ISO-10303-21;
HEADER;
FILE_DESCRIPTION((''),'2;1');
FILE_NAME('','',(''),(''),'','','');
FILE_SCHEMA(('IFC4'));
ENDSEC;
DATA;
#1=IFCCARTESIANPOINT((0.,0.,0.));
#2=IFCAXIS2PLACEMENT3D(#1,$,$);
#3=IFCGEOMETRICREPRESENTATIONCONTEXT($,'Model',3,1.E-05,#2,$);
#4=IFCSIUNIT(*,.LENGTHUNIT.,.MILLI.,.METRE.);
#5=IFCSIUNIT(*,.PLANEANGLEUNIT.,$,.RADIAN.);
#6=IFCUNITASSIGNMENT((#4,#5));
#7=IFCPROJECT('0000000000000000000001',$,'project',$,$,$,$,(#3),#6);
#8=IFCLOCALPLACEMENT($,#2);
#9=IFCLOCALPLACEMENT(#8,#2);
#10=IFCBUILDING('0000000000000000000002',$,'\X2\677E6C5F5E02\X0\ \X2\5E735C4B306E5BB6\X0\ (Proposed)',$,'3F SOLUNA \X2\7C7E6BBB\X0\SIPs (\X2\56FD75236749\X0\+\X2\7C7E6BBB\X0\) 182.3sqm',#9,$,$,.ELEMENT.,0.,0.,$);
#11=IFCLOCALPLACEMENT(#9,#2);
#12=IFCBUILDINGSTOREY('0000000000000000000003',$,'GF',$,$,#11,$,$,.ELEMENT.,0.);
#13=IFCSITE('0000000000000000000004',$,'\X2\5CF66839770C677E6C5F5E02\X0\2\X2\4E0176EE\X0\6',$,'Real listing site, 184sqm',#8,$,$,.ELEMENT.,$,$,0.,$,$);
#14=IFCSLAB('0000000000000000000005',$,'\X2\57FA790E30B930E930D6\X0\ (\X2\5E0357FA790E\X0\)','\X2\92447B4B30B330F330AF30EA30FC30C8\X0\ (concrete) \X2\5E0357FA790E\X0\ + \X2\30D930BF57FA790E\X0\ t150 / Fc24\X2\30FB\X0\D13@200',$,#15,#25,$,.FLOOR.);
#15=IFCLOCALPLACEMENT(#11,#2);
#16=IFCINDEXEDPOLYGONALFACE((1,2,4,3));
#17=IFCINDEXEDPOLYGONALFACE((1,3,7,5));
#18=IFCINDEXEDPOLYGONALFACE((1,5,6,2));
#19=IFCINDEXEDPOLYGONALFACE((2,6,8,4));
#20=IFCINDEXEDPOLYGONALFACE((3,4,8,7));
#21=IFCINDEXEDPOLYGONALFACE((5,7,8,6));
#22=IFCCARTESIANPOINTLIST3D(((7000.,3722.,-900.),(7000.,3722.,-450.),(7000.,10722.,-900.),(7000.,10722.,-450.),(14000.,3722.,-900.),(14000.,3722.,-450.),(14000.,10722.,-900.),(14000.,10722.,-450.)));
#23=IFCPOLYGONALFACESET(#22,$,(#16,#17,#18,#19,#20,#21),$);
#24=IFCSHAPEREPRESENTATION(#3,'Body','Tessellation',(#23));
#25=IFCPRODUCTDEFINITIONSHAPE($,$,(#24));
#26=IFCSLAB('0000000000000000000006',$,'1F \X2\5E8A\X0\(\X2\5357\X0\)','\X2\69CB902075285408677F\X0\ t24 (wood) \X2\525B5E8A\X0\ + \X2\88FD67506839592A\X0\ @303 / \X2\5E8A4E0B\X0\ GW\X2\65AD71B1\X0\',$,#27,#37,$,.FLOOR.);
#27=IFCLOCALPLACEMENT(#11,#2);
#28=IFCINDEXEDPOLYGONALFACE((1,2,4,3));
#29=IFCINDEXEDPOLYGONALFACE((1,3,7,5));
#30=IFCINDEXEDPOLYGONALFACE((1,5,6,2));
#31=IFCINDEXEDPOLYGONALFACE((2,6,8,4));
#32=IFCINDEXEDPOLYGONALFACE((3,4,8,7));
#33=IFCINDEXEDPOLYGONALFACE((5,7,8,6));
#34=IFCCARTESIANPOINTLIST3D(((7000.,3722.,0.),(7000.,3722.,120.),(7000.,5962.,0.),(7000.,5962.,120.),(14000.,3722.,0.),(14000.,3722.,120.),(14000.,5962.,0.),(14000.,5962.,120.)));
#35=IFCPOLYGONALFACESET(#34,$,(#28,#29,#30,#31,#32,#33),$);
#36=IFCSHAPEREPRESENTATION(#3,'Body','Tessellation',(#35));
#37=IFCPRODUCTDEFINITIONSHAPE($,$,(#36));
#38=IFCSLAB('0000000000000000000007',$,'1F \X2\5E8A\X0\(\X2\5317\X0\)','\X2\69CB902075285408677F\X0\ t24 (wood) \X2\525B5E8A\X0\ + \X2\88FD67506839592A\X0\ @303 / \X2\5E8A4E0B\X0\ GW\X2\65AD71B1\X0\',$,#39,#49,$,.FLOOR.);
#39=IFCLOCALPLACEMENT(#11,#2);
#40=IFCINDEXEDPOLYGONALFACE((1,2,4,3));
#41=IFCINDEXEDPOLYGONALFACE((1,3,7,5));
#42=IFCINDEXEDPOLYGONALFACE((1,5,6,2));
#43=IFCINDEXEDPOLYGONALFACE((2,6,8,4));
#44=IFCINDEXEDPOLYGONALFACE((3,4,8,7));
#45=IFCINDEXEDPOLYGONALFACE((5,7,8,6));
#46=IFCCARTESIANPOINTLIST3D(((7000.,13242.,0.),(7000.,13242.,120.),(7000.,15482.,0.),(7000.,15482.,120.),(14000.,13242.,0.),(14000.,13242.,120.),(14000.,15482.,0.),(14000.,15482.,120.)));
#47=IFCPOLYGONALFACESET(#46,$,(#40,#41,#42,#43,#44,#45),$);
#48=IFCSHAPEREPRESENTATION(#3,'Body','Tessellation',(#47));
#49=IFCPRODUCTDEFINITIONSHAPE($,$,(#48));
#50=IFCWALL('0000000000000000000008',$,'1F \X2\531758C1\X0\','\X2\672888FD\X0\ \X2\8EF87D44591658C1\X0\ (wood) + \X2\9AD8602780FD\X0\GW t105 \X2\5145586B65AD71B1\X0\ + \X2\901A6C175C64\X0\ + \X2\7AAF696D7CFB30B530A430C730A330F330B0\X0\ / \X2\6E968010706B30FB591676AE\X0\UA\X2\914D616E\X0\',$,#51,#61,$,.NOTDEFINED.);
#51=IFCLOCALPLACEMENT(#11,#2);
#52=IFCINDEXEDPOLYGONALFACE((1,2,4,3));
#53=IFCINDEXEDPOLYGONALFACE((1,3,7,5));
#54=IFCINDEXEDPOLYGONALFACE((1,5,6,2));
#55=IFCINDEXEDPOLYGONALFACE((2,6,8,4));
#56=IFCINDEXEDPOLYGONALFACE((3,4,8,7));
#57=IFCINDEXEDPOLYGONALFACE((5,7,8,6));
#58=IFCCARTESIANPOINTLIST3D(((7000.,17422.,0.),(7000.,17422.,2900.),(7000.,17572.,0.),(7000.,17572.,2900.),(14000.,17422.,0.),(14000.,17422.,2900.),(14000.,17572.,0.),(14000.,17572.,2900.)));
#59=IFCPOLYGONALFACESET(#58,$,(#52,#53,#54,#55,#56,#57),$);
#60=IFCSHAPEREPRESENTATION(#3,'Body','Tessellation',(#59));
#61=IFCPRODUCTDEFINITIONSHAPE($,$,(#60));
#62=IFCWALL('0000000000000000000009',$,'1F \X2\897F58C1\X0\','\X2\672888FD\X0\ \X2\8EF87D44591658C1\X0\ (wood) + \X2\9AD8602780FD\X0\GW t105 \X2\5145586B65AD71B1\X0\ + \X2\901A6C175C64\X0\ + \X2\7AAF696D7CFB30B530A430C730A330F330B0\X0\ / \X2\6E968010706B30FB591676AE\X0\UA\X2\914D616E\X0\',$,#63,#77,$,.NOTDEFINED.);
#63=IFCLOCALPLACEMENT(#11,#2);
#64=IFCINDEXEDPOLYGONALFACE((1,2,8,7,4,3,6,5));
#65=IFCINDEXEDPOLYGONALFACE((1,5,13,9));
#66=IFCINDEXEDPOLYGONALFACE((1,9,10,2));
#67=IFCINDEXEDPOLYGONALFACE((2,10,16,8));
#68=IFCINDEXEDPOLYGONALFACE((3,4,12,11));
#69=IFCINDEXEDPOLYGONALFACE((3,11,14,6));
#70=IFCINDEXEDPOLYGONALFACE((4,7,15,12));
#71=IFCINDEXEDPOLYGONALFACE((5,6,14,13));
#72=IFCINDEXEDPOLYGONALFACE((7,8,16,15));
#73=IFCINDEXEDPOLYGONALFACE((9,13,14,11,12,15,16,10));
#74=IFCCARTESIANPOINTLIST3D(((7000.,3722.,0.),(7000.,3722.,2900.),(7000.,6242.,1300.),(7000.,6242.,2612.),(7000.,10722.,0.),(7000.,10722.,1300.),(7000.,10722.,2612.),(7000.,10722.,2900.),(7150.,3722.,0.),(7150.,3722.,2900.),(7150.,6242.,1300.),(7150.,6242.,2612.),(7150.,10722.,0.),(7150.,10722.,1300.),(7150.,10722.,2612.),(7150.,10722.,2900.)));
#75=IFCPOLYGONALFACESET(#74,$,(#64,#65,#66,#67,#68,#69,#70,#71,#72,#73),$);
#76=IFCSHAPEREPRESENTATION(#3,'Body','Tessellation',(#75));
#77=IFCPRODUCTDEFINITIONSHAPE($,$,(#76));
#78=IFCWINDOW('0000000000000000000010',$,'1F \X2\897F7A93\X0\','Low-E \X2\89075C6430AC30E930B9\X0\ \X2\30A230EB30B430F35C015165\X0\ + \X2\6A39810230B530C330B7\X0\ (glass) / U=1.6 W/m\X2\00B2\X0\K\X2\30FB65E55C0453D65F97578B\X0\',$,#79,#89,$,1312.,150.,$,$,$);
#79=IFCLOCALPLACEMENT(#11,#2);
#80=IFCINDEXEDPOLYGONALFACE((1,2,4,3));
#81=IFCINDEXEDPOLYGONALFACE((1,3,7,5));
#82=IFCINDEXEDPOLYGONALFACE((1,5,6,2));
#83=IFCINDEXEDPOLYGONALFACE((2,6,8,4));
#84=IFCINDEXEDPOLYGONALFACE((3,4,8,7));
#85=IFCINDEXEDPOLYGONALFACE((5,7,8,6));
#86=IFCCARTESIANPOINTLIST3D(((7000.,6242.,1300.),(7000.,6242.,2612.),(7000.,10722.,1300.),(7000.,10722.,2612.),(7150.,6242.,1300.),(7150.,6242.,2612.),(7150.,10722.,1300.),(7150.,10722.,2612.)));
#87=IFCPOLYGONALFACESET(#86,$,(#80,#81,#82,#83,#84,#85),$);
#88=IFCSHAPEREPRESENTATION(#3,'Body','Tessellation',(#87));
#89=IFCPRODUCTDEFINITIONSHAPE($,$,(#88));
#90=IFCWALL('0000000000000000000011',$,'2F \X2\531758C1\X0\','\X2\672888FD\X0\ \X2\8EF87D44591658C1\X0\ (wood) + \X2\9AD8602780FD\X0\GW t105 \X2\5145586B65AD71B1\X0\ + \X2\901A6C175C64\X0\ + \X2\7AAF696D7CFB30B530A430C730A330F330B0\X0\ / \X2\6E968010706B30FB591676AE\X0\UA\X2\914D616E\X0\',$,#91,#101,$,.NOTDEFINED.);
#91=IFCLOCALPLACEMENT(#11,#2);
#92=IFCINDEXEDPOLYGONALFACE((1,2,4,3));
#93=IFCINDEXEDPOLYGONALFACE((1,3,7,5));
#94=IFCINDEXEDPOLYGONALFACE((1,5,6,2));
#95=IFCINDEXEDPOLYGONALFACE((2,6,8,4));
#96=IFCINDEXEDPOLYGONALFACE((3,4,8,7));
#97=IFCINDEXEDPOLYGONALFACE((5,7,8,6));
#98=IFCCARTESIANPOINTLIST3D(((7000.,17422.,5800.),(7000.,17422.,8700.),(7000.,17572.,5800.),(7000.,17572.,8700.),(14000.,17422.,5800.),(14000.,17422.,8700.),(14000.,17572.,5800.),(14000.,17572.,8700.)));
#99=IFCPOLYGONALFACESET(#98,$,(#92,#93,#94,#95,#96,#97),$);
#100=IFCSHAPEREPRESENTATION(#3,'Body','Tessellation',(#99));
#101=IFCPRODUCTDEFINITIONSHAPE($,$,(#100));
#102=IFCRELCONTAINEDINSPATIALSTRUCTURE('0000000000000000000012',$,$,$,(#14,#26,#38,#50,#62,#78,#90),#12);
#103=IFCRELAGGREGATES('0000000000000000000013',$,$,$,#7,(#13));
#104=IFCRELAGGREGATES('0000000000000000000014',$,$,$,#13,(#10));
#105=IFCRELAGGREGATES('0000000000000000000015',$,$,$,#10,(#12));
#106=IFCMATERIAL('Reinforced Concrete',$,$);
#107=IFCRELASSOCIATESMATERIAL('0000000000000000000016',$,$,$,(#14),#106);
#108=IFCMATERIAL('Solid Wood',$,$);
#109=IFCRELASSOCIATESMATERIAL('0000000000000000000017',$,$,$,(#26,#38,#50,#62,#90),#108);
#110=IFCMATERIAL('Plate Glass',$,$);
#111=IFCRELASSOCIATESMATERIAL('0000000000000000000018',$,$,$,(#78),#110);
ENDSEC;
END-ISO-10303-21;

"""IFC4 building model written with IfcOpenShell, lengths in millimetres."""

from ifc_helpers import new_model, si_unit, frame, frame_2d, origin, place, context, project, spatial, rectangle, extrude, material, element, fill, save


model = new_model("IFC4")

# Units and contexts
model_context = context("Model", 3, precision=1e-05, world=origin())
ifc_project = project(units=[si_unit("LENGTHUNIT", "METRE", prefix="MILLI"), si_unit("PLANEANGLEUNIT", "RADIAN")], contexts=[model_context])

# Site, building, storey
site_placement = place(None, origin())
site = spatial("IfcSite", under=ifc_project, at=site_placement, Name="島根県松江市2丁目6", ObjectType="Real listing site, 184sqm", CompositionType="ELEMENT", RefElevation=0.0)
building_placement = place(site_placement, origin())
building = spatial("IfcBuilding", under=site, at=building_placement, Name="松江市 平屋の家 (Proposed)", ObjectType="3F SOLUNA 籾殻SIPs (国産杉+籾殻) 182.3sqm", CompositionType="ELEMENT", ElevationOfRefHeight=0.0, ElevationOfTerrain=0.0)
storey_placement = place(building_placement, origin())
storey = spatial("IfcBuildingStorey", under=building, at=storey_placement, Name="GF", CompositionType="ELEMENT", Elevation=0.0)

# Slabs
ifc_material_1 = material(Name="Reinforced Concrete")
slab_1_placement = place(storey_placement, frame((3500.0, 1861.0, -450.0)))
element("IfcSlab", 1, at=slab_1_placement, inside=storey, material=ifc_material_1, Name="基礎スラブ (布基礎)", Description="鉄筋コンクリート (concrete) 布基礎 + ベタ基礎 t150 / Fc24・D13@200", PredefinedType="FLOOR", context=model_context, shape_type="SweptSolid", body=[
    extrude(rectangle(XDim=7000.0, YDim=7000.0, at=frame_2d((3500.0, 3500.0))), frame((3500.0, 1861.0, -450.0)), (0.0, 0.0, 1.0), 450.0),
])
ifc_material_2 = material(Name="Solid Wood")
slab_2_placement = place(storey_placement, frame((3500.0, 1861.0, 0.0)))
element("IfcSlab", 2, at=slab_2_placement, inside=storey, material=ifc_material_2, Name="1F 床(南)", Description="構造用合板 t24 (wood) 剛床 + 製材根太 @303 / 床下 GW断熱", PredefinedType="FLOOR", context=model_context, shape_type="SweptSolid", body=[
    extrude(rectangle(XDim=7000.0, YDim=2240.0, at=frame_2d((3500.0, 1120.0))), frame((3500.0, 1861.0, 0.0)), (0.0, 0.0, 1.0), 120.0),
])
slab_3_placement = place(storey_placement, frame((3500.0, 6621.0, 0.0)))
element("IfcSlab", 3, at=slab_3_placement, inside=storey, material=ifc_material_2, Name="1F 床(北)", Description="構造用合板 t24 (wood) 剛床 + 製材根太 @303 / 床下 GW断熱", PredefinedType="FLOOR", context=model_context, shape_type="SweptSolid", body=[
    extrude(rectangle(XDim=7000.0, YDim=2240.0, at=frame_2d((3500.0, 1120.0))), frame((3500.0, 6621.0, 0.0)), (0.0, 0.0, 1.0), 120.0),
])

# Shared definitions
ifc_material_3 = material(Name="Plate Glass")

# Wall
wall_1_placement = place(storey_placement, frame((3500.0, 8711.0, 0.0)))
element("IfcWall", 4, at=wall_1_placement, inside=storey, material=ifc_material_2, Name="1F 北壁", Description="木製 軸組外壁 (wood) + 高性能GW t105 充填断熱 + 通気層 + 窯業系サイディング / 準耐火・外皮UA配慮", PredefinedType="NOTDEFINED", context=model_context, shape_type="SweptSolid", body=[
    extrude(rectangle(XDim=7000.0, YDim=150.0, at=frame_2d((3500.0, 75.0))), frame((3500.0, 8711.0, 0.0)), (0.0, 0.0, 1.0), 2900.0),
])

# Wall, opening, window
wall_2_placement = place(storey_placement, frame((3500.0, 1861.0, 0.0)))
wall_2 = element("IfcWall", 5, at=wall_2_placement, inside=storey, material=ifc_material_2, Name="1F 西壁", Description="木製 軸組外壁 (wood) + 高性能GW t105 充填断熱 + 通気層 + 窯業系サイディング / 準耐火・外皮UA配慮", PredefinedType="NOTDEFINED", context=model_context, shape_type="SweptSolid", body=[
    extrude(rectangle(XDim=150.0, YDim=7000.0, at=frame_2d((75.0, 3500.0))), frame((3500.0, 1861.0, 0.0)), (0.0, 0.0, 1.0), 2900.0),
])
opening_1_placement = place(storey_placement, frame((3500.0, 3121.0, 650.0)))
opening_1 = element("IfcOpeningElement", 6, at=opening_1_placement, cuts=wall_2, PredefinedType="NOTDEFINED", context=model_context, shape_type="SweptSolid", body=[
    extrude(rectangle(XDim=150.0, YDim=4480.0, at=frame_2d((75.0, 2240.0))), frame((3500.0, 3121.0, 650.0)), (0.0, 0.0, 1.0), 1312.0),
])
window_1_placement = place(storey_placement, frame((3500.0, 3121.0, 650.0)))
window_1 = element("IfcWindow", 7, at=window_1_placement, inside=storey, material=ifc_material_3, Name="1F 西窓", Description="Low-E 複層ガラス アルゴン封入 + 樹脂サッシ (glass) / U=1.6 W/m²K・日射取得型", OverallHeight=1312.0, OverallWidth=150.0, context=model_context, shape_type="SweptSolid", body=[
    extrude(rectangle(XDim=150.0, YDim=4480.0, at=frame_2d((75.0, 2240.0))), frame((3500.0, 3121.0, 650.0)), (0.0, 0.0, 1.0), 1312.0),
])
fill(opening_1, window_1)

# Wall
wall_3_placement = place(storey_placement, frame((3500.0, 8711.0, 2900.0)))
element("IfcWall", 8, at=wall_3_placement, inside=storey, material=ifc_material_2, Name="2F 北壁", Description="木製 軸組外壁 (wood) + 高性能GW t105 充填断熱 + 通気層 + 窯業系サイディング / 準耐火・外皮UA配慮", PredefinedType="NOTDEFINED", context=model_context, shape_type="SweptSolid", body=[
    extrude(rectangle(XDim=7000.0, YDim=150.0, at=frame_2d((3500.0, 75.0))), frame((3500.0, 8711.0, 2900.0)), (0.0, 0.0, 1.0), 2900.0),
])

save(model, "model.ifc")
